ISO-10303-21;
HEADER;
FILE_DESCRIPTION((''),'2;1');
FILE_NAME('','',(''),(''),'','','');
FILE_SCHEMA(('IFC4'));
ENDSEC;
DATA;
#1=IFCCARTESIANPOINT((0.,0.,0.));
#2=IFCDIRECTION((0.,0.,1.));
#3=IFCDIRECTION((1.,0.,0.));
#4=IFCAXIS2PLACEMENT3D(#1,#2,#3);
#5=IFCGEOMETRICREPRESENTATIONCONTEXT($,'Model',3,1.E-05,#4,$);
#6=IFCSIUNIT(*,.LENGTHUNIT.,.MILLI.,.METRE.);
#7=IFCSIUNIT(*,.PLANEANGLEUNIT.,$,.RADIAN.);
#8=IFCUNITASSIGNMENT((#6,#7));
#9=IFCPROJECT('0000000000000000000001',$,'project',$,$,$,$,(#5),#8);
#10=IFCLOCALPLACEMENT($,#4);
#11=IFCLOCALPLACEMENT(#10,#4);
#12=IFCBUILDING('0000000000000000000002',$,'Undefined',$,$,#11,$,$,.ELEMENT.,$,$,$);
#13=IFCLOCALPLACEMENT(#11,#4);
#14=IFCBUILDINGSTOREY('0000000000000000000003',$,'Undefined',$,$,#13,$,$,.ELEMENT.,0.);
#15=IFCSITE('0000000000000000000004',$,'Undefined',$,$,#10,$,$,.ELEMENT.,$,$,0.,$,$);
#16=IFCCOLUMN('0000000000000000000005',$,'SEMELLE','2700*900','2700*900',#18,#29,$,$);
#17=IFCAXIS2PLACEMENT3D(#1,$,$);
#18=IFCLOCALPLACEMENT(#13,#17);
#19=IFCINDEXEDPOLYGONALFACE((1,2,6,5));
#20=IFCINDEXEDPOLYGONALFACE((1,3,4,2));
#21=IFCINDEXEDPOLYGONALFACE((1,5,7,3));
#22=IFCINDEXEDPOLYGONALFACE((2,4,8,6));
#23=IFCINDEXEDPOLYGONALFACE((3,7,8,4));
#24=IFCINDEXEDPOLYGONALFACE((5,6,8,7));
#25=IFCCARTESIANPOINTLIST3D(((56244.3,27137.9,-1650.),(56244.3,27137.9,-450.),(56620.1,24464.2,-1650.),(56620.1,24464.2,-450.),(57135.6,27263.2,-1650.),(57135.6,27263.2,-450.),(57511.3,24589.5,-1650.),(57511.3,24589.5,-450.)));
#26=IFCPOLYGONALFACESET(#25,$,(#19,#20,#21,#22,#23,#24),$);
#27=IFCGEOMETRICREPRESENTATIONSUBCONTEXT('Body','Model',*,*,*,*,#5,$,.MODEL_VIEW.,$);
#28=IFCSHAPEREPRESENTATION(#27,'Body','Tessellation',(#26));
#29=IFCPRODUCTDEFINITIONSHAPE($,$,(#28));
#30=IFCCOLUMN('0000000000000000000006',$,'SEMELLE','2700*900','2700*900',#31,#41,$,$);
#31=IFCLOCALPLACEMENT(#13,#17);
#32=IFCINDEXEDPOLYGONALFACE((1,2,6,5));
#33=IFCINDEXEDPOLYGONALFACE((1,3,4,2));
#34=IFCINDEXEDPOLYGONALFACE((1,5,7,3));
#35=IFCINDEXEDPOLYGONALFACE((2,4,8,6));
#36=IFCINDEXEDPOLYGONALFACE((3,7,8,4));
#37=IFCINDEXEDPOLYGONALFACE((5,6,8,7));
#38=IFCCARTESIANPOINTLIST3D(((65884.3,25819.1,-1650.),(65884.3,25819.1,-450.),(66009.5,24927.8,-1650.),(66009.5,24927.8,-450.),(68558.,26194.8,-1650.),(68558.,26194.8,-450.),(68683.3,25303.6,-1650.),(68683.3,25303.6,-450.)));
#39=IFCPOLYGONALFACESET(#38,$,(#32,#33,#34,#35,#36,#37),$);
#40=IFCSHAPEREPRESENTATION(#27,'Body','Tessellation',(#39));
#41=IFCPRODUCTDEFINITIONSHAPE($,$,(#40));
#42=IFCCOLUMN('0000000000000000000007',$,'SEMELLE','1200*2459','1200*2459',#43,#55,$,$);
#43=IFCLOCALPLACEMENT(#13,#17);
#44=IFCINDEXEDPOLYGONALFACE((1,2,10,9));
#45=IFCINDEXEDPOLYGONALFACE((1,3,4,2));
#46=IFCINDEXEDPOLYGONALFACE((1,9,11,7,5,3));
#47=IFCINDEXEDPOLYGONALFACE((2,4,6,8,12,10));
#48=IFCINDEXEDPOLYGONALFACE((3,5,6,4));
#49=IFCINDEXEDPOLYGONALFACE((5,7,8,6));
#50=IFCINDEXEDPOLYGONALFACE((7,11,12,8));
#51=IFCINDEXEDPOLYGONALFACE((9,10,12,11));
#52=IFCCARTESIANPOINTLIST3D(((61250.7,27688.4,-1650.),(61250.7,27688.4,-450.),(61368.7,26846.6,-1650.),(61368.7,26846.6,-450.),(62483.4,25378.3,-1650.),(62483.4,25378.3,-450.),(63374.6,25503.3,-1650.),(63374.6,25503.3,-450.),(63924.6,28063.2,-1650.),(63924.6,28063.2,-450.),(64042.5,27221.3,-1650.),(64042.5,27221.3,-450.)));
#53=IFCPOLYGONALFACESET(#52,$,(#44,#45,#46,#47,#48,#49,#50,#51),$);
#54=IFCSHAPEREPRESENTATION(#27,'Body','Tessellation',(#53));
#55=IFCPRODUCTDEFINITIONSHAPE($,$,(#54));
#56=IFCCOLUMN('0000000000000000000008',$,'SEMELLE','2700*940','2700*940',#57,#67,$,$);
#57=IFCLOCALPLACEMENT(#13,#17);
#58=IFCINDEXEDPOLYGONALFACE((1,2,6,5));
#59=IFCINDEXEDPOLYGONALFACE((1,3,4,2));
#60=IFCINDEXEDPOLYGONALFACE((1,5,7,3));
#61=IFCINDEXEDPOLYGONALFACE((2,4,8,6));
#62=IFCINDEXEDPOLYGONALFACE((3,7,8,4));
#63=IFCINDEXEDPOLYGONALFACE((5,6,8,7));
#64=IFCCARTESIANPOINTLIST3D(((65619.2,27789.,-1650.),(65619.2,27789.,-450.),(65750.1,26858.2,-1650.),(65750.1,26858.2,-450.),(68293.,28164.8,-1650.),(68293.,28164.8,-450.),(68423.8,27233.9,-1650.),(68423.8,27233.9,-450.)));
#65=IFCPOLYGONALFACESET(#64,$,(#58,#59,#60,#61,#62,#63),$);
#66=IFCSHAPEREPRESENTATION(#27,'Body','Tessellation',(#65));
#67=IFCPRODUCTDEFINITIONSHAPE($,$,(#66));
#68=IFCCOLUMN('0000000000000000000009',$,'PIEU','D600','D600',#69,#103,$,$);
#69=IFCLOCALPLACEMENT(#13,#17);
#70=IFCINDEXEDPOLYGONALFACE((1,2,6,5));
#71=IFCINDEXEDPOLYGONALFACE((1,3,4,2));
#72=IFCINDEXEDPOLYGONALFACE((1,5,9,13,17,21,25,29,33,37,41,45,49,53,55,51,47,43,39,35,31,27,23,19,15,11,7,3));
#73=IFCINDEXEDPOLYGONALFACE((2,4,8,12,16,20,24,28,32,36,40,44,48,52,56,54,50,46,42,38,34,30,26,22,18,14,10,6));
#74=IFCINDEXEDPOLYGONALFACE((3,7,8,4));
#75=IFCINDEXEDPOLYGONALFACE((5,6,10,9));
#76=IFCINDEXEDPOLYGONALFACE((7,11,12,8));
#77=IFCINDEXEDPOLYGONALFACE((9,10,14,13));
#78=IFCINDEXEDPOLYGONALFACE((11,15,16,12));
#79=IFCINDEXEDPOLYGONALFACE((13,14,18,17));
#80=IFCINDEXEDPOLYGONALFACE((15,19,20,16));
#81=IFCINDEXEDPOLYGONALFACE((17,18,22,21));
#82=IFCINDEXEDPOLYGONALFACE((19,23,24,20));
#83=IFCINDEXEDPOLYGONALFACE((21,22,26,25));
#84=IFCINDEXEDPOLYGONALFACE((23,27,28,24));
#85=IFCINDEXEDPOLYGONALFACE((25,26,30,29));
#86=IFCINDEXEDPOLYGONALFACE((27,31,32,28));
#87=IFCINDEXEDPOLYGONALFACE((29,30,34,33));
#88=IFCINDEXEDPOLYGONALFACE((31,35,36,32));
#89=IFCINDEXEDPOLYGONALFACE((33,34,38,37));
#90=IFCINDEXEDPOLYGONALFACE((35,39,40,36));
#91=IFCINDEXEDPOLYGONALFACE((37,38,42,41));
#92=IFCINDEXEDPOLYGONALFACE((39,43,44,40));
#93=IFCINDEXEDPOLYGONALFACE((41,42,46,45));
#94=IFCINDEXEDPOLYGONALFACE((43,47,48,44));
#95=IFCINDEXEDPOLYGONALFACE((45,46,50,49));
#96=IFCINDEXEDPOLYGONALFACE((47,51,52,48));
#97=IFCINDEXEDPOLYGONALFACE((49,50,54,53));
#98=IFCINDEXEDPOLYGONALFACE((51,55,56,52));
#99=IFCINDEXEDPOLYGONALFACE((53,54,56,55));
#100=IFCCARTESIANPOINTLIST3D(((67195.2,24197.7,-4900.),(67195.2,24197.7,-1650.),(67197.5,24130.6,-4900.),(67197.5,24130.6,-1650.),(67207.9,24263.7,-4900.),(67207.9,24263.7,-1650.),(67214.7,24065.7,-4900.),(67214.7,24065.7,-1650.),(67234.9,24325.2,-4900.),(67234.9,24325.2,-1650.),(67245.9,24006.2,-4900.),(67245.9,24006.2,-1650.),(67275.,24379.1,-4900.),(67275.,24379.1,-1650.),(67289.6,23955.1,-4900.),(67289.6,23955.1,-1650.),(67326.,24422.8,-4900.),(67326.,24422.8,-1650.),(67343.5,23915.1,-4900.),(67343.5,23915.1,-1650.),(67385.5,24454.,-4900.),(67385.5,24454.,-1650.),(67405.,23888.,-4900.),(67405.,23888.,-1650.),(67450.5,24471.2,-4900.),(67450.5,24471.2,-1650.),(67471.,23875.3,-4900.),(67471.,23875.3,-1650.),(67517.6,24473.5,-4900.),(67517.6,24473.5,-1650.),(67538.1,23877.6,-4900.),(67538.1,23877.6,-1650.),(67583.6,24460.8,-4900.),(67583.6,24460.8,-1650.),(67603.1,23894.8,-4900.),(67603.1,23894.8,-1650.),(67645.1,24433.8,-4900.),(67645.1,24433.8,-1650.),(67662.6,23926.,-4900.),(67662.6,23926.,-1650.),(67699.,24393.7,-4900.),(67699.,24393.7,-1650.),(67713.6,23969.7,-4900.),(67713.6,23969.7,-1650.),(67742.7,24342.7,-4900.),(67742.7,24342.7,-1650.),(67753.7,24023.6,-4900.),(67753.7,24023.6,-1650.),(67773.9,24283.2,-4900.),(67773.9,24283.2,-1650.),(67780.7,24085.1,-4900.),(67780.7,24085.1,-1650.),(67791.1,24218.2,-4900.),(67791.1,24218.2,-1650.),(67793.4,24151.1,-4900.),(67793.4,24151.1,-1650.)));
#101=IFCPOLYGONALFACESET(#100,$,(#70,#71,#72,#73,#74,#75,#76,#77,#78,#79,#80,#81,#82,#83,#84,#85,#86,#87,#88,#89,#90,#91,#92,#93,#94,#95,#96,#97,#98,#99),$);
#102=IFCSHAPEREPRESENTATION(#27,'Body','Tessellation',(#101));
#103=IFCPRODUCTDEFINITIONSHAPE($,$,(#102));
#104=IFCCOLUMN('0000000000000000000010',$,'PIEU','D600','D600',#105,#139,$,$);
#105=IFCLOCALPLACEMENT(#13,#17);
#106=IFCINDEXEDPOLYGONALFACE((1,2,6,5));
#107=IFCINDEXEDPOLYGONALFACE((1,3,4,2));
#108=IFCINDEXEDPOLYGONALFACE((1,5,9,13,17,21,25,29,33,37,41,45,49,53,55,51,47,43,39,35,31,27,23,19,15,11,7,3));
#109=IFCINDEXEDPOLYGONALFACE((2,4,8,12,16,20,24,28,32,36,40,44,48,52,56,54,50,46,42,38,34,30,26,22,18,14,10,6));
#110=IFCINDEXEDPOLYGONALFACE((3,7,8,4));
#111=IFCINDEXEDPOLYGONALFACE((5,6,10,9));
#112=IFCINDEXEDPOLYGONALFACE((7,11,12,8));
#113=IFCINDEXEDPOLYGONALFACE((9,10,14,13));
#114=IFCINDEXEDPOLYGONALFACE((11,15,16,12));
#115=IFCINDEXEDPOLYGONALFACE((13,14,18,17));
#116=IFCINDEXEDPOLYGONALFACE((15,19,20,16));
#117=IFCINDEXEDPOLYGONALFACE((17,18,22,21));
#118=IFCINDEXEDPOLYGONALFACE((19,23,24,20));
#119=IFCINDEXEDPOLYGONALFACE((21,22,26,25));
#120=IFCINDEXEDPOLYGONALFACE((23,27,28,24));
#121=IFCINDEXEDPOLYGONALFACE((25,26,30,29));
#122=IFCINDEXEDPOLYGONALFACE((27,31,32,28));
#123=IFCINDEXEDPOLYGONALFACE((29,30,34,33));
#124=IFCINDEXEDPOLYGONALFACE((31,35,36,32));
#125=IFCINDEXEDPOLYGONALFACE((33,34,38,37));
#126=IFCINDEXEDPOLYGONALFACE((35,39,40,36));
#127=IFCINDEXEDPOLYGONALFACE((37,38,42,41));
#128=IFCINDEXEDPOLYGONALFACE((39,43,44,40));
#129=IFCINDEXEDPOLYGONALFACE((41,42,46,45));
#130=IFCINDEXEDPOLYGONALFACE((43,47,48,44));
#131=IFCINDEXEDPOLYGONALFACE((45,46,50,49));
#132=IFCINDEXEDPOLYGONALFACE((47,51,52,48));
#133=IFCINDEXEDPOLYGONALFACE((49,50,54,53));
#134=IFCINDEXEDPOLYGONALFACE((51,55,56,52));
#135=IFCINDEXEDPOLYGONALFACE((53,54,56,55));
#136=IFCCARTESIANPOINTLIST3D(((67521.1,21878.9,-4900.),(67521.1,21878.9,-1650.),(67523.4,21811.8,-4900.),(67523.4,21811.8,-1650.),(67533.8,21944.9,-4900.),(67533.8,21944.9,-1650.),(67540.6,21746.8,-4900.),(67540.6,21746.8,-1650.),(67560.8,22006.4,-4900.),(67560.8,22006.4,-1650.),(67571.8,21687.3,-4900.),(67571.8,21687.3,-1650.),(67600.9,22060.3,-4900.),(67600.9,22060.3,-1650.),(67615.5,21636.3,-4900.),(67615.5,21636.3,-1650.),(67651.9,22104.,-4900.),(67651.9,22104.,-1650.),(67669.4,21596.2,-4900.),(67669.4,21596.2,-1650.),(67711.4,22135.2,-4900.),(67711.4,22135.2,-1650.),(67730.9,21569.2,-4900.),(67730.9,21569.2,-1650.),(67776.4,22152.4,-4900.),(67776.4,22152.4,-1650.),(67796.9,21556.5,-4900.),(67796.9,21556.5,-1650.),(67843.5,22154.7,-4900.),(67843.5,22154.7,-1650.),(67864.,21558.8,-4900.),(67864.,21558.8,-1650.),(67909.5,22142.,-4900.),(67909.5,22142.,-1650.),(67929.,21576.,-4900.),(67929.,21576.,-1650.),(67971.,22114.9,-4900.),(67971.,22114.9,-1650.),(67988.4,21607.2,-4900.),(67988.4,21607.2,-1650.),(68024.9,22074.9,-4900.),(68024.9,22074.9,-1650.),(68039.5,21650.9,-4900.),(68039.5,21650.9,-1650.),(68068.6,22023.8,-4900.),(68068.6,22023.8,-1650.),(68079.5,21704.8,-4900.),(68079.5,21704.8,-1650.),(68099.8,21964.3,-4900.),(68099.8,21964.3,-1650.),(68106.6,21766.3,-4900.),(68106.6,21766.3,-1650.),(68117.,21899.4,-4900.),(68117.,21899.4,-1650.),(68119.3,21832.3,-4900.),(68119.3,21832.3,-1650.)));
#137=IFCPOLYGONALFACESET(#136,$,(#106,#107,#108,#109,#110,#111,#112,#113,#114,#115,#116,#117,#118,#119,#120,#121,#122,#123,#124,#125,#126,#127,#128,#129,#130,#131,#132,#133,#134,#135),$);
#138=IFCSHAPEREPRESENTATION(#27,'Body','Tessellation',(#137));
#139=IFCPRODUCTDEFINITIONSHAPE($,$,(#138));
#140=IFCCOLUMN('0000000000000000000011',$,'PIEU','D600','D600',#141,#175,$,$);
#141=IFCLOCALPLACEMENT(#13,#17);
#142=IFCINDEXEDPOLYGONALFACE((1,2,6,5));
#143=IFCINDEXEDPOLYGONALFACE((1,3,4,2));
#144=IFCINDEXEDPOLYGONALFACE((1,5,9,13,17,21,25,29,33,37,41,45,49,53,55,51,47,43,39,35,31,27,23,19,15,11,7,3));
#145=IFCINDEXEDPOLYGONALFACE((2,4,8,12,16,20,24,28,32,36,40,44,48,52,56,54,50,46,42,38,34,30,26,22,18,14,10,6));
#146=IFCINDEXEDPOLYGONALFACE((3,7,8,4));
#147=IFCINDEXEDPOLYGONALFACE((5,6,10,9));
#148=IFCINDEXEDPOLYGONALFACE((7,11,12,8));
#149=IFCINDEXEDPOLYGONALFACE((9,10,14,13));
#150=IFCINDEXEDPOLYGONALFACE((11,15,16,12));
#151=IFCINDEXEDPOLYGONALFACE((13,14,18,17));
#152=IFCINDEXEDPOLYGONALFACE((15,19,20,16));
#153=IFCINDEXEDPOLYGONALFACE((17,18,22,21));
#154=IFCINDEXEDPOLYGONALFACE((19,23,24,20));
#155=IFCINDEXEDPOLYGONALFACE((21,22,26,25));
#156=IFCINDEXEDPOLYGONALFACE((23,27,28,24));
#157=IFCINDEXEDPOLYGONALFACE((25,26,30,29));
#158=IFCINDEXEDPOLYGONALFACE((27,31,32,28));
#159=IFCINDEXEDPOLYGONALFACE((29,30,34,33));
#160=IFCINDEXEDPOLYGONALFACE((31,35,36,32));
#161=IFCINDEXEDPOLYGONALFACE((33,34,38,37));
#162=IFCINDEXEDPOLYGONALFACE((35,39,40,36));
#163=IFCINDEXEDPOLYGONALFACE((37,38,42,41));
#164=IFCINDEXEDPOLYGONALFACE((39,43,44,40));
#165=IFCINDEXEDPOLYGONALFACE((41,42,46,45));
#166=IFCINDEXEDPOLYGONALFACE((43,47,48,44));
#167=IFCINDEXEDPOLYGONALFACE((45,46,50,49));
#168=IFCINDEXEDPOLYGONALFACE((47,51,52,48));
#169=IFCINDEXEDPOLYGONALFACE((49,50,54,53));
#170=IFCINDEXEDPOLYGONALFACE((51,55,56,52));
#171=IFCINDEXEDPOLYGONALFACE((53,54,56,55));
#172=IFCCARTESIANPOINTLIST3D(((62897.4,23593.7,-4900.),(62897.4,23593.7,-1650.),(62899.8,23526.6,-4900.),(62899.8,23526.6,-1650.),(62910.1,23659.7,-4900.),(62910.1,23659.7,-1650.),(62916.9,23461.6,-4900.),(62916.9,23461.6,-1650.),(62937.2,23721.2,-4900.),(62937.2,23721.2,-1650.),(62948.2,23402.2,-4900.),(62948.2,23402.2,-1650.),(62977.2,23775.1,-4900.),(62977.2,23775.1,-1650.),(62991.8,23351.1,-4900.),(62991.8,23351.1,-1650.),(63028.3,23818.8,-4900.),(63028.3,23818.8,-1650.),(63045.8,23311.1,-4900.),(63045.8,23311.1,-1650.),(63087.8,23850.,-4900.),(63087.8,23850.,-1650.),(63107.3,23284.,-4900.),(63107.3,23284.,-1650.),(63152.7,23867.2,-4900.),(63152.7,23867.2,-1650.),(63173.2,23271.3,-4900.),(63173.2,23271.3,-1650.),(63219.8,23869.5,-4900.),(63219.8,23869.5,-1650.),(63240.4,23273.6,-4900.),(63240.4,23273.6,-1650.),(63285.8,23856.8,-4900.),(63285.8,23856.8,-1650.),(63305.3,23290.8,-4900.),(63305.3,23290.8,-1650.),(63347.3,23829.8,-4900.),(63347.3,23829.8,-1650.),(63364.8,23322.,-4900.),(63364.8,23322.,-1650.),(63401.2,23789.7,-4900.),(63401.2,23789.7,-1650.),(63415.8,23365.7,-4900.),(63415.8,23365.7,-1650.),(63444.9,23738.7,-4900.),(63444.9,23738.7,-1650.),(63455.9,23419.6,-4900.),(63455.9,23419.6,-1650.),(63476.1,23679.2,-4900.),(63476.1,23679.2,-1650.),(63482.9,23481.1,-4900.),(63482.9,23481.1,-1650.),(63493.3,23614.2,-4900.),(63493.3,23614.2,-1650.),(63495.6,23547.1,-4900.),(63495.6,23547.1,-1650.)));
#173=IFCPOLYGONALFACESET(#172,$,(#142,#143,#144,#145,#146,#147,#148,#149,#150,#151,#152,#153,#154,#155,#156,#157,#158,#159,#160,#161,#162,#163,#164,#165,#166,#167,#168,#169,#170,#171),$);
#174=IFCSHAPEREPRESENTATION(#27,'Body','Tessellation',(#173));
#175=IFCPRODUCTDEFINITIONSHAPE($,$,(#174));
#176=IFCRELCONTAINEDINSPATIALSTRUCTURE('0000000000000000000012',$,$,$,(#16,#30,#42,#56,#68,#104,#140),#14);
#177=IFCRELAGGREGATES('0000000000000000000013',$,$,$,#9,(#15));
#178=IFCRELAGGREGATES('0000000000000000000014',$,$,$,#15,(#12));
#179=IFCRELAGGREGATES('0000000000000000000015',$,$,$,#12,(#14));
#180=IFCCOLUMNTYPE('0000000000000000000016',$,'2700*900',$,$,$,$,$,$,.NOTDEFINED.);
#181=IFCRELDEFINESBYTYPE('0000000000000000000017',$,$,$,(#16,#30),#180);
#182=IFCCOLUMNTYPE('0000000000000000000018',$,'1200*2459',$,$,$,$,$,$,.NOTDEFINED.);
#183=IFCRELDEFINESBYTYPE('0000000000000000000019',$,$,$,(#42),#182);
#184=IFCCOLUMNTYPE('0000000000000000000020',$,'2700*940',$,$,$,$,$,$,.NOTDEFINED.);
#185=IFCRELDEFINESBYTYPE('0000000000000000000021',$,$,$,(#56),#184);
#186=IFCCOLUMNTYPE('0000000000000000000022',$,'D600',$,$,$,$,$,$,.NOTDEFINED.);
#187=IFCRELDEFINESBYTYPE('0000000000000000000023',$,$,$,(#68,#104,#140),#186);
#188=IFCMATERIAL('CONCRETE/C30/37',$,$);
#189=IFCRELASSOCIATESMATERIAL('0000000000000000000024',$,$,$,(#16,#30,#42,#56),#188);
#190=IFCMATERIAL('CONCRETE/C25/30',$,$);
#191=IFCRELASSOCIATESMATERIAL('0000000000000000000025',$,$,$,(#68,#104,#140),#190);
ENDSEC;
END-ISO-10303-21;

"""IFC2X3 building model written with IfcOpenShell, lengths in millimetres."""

from ifc_helpers import new_model, si_unit, frame, origin_with_axes, origin_2d_with_axis, place, context, subcontext, project, spatial, polyline, rectangle, circle, outline, extrude, material, type_object, element, save


model = new_model("IFC2X3")

# Units and contexts
model_context = context("Model", 3, precision=1e-05, world=origin_with_axes())
body_context = subcontext(model_context, "Body", "Model", "MODEL_VIEW")
ifc_project = project(units=[si_unit("LENGTHUNIT", "METRE", prefix="MILLI"), si_unit("PLANEANGLEUNIT", "RADIAN")], contexts=[model_context])

# Site, building, storey
site_placement = place(None, origin_with_axes())
site = spatial("IfcSite", under=ifc_project, at=site_placement, Name="Undefined", CompositionType="ELEMENT", RefElevation=0.0)
building_placement = place(site_placement, origin_with_axes())
building = spatial("IfcBuilding", under=site, at=building_placement, Name="Undefined", CompositionType="ELEMENT")
storey_placement = place(building_placement, origin_with_axes())
storey = spatial("IfcBuildingStorey", under=building, at=storey_placement, Name="Undefined", CompositionType="ELEMENT", Elevation=0.0)

# Columns
ifc_material_1 = material(Name="CONCRETE/C30/37")
column_type_1 = type_object("IfcColumnType", Name="2700*900", PredefinedType="NOTDEFINED")
column_1_placement = place(storey_placement, frame((56877.8, 25863.7, -1650.0), z_axis=(0.0, 0.0, 1.0), x_axis=(1.0, 0.0, 0.0)))
element("IfcColumn", 1, at=column_1_placement, inside=storey, type_object=column_type_1, material=ifc_material_1, Name="SEMELLE", Description="2700*900", ObjectType="2700*900", context=body_context, shape_type="SweptSolid", body=[
    extrude(rectangle(XDim=900.0, YDim=2700.0, at=origin_2d_with_axis()), frame((0.0, 0.0, 1200.0), z_axis=(0.0, 0.0, -1.0), x_axis=(-0.990268, -0.139173, 0.0)), (0.0, 0.0, 1.0), 1200.0),
])
column_2_placement = place(storey_placement, frame((67283.8, 25561.3, -1650.0), z_axis=(0.0, 0.0, 1.0), x_axis=(1.0, 0.0, 0.0)))
element("IfcColumn", 2, at=column_2_placement, inside=storey, type_object=column_type_1, material=ifc_material_1, Name="SEMELLE", Description="2700*900", ObjectType="2700*900", context=body_context, shape_type="SweptSolid", body=[
    extrude(rectangle(XDim=900.0, YDim=2700.0, at=origin_2d_with_axis()), frame((0.0, 0.0, 1200.0), z_axis=(0.0, 0.0, -1.0), x_axis=(0.139173, -0.990268, 0.0)), (0.0, 0.0, 1.0), 1200.0),
])
column_type_2 = type_object("IfcColumnType", Name="1200*2459", PredefinedType="NOTDEFINED")
column_3_placement = place(storey_placement, frame((63924.6, 28063.2, -1050.0), z_axis=(0.0, 0.0, 1.0), x_axis=(-0.990317, -0.138827, 0.0)))
element("IfcColumn", 3, at=column_3_placement, inside=storey, type_object=column_type_2, material=ifc_material_1, Name="SEMELLE", Description="1200*2459", ObjectType="1200*2459", context=body_context, shape_type="SweptSolid", body=[
    extrude(outline(polyline([(0.0, 0.0), (2700.0, 0.0), (2700.0, 850.0), (1800.0, 2458.8), (900.0, 2458.8), (0.1, 850.1), (0.0, 0.0)])), frame((0.0, 0.0, -600.0), z_axis=(0.0, 0.0, 1.0), x_axis=(1.0, 0.0, 0.0)), (0.0, 0.0, 1.0), 1200.0),
])
column_type_3 = type_object("IfcColumnType", Name="2700*940", PredefinedType="NOTDEFINED")
column_4_placement = place(storey_placement, frame((67021.5, 27511.5, -1650.0), z_axis=(0.0, 0.0, 1.0), x_axis=(1.0, 0.0, 0.0)))
element("IfcColumn", 4, at=column_4_placement, inside=storey, type_object=column_type_3, material=ifc_material_1, Name="SEMELLE", Description="2700*940", ObjectType="2700*940", context=body_context, shape_type="SweptSolid", body=[
    extrude(rectangle(XDim=940.0, YDim=2700.0, at=origin_2d_with_axis()), frame((0.0, 0.0, 1200.0), z_axis=(0.0, 0.0, -1.0), x_axis=(0.139173, -0.990268, 0.0)), (0.0, 0.0, 1.0), 1200.0),
])
ifc_material_2 = material(Name="CONCRETE/C25/30")
column_type_4 = type_object("IfcColumnType", Name="D600", PredefinedType="NOTDEFINED")
for number, where, z_axis, x_axis, name in (
    (5, (67494.3, 24174.4, -4900.0), (0.0, 0.0, 1.0), (1.0, 0.0, 0.0), "PIEU"),
    (6, (67820.2, 21855.6, -4900.0), (0.0, 0.0, 1.0), (1.0, 0.0, 0.0), "PIEU"),
    (7, (63196.5, 23570.4, -4900.0), (0.0, 0.0, 1.0), (1.0, 0.0, 0.0), "PIEU"),
):
    element("IfcColumn", number, at=place(storey_placement, frame(where, z_axis=z_axis, x_axis=x_axis)), inside=storey, type_object=column_type_4, material=ifc_material_2, Name=name, Description="D600", ObjectType="D600", context=body_context, shape_type="SweptSolid", body=[
        extrude(circle(Radius=300.0, at=origin_2d_with_axis()), frame((0.0, 0.0, 3250.0), z_axis=(0.0, 0.0, -1.0), x_axis=(0.146083, -0.989272, 0.0)), (0.0, 0.0, 1.0), 3250.0),
    ])

save(model, "model.ifc")
